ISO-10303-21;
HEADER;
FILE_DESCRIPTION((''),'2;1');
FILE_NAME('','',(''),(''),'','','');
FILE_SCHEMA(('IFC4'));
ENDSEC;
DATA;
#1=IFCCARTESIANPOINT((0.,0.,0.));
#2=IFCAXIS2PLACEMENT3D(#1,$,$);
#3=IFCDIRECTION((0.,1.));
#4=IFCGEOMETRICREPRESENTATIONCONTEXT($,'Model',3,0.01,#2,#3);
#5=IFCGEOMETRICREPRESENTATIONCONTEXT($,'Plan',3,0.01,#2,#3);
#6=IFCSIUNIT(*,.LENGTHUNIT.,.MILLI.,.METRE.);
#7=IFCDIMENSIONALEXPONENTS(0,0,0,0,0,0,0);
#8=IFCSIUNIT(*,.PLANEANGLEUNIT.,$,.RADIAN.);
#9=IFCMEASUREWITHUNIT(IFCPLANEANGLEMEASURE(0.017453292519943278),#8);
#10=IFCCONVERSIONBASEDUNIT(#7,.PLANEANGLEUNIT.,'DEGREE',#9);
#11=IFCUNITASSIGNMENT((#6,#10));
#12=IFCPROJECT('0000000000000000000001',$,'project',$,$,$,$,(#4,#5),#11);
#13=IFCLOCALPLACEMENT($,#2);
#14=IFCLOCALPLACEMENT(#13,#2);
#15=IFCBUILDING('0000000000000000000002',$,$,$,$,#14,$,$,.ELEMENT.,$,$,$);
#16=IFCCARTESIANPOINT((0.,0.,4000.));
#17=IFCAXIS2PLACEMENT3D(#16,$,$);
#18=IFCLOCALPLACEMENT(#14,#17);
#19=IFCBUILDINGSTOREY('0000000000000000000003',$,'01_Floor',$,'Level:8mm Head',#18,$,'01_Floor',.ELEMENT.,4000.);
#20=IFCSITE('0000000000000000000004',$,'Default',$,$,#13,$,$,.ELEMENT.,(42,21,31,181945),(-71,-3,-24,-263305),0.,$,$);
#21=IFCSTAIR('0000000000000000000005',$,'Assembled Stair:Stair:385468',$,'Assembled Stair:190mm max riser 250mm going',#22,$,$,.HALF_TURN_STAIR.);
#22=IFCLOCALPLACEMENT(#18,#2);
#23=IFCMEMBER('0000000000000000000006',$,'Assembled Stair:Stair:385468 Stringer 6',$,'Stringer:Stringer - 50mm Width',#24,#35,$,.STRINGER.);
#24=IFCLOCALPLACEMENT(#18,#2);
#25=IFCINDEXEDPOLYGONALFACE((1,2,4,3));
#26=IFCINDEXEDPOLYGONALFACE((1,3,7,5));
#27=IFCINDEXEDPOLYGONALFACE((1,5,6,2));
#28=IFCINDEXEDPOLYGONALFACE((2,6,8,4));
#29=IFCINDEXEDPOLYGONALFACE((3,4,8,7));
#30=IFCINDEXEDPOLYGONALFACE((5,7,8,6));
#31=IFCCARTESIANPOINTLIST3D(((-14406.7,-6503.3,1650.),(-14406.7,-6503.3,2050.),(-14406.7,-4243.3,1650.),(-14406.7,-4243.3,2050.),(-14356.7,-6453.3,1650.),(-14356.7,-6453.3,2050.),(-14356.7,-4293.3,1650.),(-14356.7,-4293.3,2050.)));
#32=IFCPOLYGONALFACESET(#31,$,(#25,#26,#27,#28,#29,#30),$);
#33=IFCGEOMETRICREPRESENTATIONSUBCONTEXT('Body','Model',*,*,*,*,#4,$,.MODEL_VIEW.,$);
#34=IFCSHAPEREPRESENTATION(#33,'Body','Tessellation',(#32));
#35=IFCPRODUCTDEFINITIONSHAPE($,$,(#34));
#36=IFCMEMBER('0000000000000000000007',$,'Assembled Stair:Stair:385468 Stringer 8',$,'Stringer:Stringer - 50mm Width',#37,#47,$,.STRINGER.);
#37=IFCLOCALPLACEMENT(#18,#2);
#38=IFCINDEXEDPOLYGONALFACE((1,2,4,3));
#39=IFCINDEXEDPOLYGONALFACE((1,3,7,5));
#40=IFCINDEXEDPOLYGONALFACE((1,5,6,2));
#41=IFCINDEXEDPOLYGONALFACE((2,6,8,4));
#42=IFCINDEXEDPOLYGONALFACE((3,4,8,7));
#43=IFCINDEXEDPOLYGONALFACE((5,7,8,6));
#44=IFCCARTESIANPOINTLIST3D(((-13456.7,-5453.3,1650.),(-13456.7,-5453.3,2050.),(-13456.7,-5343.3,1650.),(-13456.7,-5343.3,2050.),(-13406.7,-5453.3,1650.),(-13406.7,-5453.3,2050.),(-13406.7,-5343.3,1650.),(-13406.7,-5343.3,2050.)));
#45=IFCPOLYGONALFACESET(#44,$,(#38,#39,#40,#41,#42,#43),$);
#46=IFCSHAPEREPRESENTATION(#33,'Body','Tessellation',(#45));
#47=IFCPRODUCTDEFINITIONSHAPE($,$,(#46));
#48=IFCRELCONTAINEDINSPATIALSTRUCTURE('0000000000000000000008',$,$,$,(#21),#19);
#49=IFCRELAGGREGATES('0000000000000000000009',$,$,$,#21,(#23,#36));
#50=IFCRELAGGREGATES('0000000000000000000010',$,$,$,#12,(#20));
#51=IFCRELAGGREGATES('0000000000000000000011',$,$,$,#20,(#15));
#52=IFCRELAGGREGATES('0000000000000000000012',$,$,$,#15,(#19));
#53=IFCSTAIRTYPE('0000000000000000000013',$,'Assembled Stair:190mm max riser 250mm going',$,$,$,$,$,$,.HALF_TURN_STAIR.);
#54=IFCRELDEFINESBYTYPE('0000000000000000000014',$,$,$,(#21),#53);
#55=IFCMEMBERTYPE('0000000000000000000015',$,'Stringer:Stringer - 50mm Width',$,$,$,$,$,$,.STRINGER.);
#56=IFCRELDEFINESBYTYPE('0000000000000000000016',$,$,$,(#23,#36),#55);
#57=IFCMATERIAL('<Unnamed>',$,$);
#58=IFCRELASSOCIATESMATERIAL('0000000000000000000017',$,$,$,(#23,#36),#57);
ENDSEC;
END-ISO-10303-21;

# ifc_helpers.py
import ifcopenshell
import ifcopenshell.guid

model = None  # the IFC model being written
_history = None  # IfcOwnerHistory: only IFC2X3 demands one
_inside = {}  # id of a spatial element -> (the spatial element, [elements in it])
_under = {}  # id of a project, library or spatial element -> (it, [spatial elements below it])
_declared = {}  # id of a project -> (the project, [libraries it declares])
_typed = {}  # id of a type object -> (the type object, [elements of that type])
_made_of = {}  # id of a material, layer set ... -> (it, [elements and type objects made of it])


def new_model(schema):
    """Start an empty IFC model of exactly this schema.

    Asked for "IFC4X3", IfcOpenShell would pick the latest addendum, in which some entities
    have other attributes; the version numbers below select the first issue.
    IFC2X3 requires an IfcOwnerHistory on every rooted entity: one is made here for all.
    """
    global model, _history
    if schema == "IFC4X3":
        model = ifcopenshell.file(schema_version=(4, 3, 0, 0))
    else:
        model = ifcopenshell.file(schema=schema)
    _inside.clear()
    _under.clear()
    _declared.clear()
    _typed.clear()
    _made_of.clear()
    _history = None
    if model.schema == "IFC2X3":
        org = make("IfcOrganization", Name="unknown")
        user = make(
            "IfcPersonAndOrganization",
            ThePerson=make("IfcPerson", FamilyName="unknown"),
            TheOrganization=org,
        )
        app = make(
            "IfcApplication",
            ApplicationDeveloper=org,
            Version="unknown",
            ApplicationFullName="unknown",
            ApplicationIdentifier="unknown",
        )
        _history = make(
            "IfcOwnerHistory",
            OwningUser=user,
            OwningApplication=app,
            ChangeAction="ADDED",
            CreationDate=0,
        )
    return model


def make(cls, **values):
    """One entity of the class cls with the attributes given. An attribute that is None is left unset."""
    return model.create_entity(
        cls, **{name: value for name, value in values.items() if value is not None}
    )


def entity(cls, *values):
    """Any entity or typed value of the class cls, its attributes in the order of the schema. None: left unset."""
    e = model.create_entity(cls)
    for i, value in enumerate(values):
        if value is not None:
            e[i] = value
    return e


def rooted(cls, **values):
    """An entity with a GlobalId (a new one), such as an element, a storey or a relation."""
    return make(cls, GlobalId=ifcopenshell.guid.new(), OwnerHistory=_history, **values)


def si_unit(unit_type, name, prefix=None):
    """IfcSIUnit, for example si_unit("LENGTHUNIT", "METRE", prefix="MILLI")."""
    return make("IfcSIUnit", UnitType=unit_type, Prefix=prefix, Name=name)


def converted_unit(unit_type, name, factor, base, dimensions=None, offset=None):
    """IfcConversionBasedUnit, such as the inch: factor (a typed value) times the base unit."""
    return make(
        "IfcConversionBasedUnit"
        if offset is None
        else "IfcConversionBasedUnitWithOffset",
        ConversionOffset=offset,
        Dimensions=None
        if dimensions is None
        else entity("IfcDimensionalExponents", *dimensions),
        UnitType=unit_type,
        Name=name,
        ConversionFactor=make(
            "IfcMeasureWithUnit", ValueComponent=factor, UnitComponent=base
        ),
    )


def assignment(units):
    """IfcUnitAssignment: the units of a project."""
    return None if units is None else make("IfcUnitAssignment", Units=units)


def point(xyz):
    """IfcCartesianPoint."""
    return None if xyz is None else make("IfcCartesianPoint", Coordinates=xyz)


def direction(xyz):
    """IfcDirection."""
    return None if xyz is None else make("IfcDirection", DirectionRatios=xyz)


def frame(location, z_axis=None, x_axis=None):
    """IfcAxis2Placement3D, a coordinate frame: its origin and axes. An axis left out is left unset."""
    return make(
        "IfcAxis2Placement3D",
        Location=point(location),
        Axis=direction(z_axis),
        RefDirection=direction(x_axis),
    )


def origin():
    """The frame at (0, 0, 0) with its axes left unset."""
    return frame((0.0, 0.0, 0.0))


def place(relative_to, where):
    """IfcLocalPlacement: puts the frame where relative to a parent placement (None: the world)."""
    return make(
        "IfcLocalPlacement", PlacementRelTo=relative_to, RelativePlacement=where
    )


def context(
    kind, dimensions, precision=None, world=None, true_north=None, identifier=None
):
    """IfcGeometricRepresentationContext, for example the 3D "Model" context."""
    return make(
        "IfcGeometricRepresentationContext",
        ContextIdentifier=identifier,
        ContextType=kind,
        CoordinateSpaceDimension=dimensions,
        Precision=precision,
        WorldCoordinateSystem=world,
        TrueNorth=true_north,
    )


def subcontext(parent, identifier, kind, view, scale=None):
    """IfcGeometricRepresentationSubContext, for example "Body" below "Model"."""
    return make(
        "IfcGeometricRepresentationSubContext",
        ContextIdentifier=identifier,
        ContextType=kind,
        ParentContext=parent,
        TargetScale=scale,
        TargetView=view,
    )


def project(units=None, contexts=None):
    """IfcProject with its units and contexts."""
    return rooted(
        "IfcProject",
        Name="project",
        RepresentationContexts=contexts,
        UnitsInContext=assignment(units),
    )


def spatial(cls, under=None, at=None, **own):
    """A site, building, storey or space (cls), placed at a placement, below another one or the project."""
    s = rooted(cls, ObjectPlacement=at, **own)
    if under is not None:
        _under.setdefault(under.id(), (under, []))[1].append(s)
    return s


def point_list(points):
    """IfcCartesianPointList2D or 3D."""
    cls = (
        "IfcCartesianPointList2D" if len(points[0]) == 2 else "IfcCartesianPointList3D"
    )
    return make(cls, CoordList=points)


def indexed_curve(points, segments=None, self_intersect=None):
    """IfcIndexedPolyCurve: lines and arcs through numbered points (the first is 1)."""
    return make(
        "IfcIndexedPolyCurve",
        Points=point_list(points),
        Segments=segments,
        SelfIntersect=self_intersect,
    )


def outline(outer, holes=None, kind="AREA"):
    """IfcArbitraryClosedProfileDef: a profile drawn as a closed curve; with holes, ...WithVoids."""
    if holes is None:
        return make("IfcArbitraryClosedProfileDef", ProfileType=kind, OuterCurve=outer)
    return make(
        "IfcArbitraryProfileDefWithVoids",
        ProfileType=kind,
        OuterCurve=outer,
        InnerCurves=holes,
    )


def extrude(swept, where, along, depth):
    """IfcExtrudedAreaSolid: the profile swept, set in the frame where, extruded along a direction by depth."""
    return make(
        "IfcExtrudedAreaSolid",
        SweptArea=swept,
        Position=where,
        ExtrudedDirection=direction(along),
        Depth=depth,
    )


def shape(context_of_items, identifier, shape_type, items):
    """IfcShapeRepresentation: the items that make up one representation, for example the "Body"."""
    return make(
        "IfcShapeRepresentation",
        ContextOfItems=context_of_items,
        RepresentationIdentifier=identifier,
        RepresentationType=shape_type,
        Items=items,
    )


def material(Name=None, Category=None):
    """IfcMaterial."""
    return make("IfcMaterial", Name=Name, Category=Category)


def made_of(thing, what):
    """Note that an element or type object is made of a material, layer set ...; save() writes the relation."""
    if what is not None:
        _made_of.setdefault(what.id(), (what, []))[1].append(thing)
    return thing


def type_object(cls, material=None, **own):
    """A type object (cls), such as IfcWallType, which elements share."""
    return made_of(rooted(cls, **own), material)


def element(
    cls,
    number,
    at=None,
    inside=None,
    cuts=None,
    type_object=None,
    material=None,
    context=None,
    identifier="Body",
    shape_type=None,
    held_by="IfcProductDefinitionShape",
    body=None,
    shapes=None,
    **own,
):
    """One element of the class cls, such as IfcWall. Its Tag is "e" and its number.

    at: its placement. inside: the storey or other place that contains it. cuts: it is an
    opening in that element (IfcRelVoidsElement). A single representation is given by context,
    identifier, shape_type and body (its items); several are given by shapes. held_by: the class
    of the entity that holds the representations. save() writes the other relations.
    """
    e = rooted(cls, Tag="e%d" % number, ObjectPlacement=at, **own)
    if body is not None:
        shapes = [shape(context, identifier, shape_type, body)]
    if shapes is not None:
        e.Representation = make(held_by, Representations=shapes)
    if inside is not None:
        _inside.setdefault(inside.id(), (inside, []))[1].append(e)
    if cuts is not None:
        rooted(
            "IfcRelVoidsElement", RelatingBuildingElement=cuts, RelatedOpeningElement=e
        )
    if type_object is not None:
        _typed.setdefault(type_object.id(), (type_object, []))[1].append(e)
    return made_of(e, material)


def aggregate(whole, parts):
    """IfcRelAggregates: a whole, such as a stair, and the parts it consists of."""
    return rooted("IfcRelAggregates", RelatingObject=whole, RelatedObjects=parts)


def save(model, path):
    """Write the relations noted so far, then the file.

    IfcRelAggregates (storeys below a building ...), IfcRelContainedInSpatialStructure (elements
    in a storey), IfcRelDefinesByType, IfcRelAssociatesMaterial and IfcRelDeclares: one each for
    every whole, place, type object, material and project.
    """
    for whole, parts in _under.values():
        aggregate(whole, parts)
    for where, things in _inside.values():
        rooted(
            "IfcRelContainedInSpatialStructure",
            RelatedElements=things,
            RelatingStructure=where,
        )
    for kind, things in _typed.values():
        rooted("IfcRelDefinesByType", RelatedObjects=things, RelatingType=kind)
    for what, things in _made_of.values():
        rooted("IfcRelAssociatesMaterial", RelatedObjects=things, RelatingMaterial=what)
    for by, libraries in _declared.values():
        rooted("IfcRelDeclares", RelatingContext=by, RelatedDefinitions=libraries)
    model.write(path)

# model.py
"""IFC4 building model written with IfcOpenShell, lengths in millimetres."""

from ifc_helpers import new_model, entity, si_unit, converted_unit, direction, frame, origin, place, context, subcontext, project, spatial, indexed_curve, outline, extrude, material, type_object, element, aggregate, save


model = new_model("IFC4")

# Units and contexts
model_context = context("Model", 3, precision=0.01, world=origin(), true_north=direction((0.0, 1.0)))
plan_context = context("Plan", 3, precision=0.01, world=origin(), true_north=direction((0.0, 1.0)))
body_context = subcontext(model_context, "Body", "Model", "MODEL_VIEW")
ifc_project = project(units=[si_unit("LENGTHUNIT", "METRE", prefix="MILLI"), converted_unit("PLANEANGLEUNIT", "DEGREE", entity("IfcPlaneAngleMeasure", 0.017453292519943278), si_unit("PLANEANGLEUNIT", "RADIAN"), dimensions=[0, 0, 0, 0, 0, 0, 0])], contexts=[model_context, plan_context])

# Site, building, storey
site_placement = place(None, origin())
site = spatial("IfcSite", under=ifc_project, at=site_placement, Name="Default", CompositionType="ELEMENT", RefLatitude=(42, 21, 31, 181945), RefLongitude=(-71, -3, -24, -263305), RefElevation=0.0)
building_placement = place(site_placement, origin())
building = spatial("IfcBuilding", under=site, at=building_placement, CompositionType="ELEMENT")
storey_placement = place(building_placement, frame((0.0, 0.0, 4000.0)))
storey = spatial("IfcBuildingStorey", under=building, at=storey_placement, Name="01_Floor", ObjectType="Level:8mm Head", LongName="01_Floor", CompositionType="ELEMENT", Elevation=4000.0)

# Stair, members
stair_type = type_object("IfcStairType", Name="Assembled Stair:190mm max riser 250mm going", PredefinedType="HALF_TURN_STAIR")
stair_placement = place(storey_placement, origin())
stair = element("IfcStair", 1, at=stair_placement, inside=storey, type_object=stair_type, Name="Assembled Stair:Stair:385468", ObjectType="Assembled Stair:190mm max riser 250mm going", PredefinedType="HALF_TURN_STAIR")
ifc_material_1 = material(Name="<Unnamed>")
member_type = type_object("IfcMemberType", Name="Stringer:Stringer - 50mm Width", PredefinedType="STRINGER")
member_1_placement = place(stair_placement, origin())
member_1 = element("IfcMember", 2, at=member_1_placement, type_object=member_type, material=ifc_material_1, Name="Assembled Stair:Stair:385468 Stringer 6", ObjectType="Stringer:Stringer - 50mm Width", PredefinedType="STRINGER", context=body_context, shape_type="SweptSolid", body=[
    extrude(outline(indexed_curve([(-1130.0, -25.0), (1130.0, -25.0), (1080.0, 25.0), (-1080.0, 25.0), (-1130.0, -25.0)], self_intersect=False)), frame((-14381.7, -5373.3, 1650.0), z_axis=(0.0, 0.0, 1.0), x_axis=(0.0, -1.0, 0.0)), (0.0, 0.0, 1.0), 400.0),
])
member_2_placement = place(stair_placement, origin())
member_2 = element("IfcMember", 3, at=member_2_placement, type_object=member_type, material=ifc_material_1, Name="Assembled Stair:Stair:385468 Stringer 8", ObjectType="Stringer:Stringer - 50mm Width", PredefinedType="STRINGER", context=body_context, shape_type="SweptSolid", body=[
    extrude(outline(indexed_curve([(-55.0, -25.0), (55.0, -25.0), (55.0, 25.0), (-55.0, 25.0), (-55.0, -25.0)], self_intersect=False)), frame((-13431.7, -5398.3, 1650.0), z_axis=(0.0, 0.0, 1.0), x_axis=(0.0, 1.0, 0.0)), (0.0, 0.0, 1.0), 400.0),
])

aggregate(stair, [member_1, member_2])

save(model, "model.ifc")
